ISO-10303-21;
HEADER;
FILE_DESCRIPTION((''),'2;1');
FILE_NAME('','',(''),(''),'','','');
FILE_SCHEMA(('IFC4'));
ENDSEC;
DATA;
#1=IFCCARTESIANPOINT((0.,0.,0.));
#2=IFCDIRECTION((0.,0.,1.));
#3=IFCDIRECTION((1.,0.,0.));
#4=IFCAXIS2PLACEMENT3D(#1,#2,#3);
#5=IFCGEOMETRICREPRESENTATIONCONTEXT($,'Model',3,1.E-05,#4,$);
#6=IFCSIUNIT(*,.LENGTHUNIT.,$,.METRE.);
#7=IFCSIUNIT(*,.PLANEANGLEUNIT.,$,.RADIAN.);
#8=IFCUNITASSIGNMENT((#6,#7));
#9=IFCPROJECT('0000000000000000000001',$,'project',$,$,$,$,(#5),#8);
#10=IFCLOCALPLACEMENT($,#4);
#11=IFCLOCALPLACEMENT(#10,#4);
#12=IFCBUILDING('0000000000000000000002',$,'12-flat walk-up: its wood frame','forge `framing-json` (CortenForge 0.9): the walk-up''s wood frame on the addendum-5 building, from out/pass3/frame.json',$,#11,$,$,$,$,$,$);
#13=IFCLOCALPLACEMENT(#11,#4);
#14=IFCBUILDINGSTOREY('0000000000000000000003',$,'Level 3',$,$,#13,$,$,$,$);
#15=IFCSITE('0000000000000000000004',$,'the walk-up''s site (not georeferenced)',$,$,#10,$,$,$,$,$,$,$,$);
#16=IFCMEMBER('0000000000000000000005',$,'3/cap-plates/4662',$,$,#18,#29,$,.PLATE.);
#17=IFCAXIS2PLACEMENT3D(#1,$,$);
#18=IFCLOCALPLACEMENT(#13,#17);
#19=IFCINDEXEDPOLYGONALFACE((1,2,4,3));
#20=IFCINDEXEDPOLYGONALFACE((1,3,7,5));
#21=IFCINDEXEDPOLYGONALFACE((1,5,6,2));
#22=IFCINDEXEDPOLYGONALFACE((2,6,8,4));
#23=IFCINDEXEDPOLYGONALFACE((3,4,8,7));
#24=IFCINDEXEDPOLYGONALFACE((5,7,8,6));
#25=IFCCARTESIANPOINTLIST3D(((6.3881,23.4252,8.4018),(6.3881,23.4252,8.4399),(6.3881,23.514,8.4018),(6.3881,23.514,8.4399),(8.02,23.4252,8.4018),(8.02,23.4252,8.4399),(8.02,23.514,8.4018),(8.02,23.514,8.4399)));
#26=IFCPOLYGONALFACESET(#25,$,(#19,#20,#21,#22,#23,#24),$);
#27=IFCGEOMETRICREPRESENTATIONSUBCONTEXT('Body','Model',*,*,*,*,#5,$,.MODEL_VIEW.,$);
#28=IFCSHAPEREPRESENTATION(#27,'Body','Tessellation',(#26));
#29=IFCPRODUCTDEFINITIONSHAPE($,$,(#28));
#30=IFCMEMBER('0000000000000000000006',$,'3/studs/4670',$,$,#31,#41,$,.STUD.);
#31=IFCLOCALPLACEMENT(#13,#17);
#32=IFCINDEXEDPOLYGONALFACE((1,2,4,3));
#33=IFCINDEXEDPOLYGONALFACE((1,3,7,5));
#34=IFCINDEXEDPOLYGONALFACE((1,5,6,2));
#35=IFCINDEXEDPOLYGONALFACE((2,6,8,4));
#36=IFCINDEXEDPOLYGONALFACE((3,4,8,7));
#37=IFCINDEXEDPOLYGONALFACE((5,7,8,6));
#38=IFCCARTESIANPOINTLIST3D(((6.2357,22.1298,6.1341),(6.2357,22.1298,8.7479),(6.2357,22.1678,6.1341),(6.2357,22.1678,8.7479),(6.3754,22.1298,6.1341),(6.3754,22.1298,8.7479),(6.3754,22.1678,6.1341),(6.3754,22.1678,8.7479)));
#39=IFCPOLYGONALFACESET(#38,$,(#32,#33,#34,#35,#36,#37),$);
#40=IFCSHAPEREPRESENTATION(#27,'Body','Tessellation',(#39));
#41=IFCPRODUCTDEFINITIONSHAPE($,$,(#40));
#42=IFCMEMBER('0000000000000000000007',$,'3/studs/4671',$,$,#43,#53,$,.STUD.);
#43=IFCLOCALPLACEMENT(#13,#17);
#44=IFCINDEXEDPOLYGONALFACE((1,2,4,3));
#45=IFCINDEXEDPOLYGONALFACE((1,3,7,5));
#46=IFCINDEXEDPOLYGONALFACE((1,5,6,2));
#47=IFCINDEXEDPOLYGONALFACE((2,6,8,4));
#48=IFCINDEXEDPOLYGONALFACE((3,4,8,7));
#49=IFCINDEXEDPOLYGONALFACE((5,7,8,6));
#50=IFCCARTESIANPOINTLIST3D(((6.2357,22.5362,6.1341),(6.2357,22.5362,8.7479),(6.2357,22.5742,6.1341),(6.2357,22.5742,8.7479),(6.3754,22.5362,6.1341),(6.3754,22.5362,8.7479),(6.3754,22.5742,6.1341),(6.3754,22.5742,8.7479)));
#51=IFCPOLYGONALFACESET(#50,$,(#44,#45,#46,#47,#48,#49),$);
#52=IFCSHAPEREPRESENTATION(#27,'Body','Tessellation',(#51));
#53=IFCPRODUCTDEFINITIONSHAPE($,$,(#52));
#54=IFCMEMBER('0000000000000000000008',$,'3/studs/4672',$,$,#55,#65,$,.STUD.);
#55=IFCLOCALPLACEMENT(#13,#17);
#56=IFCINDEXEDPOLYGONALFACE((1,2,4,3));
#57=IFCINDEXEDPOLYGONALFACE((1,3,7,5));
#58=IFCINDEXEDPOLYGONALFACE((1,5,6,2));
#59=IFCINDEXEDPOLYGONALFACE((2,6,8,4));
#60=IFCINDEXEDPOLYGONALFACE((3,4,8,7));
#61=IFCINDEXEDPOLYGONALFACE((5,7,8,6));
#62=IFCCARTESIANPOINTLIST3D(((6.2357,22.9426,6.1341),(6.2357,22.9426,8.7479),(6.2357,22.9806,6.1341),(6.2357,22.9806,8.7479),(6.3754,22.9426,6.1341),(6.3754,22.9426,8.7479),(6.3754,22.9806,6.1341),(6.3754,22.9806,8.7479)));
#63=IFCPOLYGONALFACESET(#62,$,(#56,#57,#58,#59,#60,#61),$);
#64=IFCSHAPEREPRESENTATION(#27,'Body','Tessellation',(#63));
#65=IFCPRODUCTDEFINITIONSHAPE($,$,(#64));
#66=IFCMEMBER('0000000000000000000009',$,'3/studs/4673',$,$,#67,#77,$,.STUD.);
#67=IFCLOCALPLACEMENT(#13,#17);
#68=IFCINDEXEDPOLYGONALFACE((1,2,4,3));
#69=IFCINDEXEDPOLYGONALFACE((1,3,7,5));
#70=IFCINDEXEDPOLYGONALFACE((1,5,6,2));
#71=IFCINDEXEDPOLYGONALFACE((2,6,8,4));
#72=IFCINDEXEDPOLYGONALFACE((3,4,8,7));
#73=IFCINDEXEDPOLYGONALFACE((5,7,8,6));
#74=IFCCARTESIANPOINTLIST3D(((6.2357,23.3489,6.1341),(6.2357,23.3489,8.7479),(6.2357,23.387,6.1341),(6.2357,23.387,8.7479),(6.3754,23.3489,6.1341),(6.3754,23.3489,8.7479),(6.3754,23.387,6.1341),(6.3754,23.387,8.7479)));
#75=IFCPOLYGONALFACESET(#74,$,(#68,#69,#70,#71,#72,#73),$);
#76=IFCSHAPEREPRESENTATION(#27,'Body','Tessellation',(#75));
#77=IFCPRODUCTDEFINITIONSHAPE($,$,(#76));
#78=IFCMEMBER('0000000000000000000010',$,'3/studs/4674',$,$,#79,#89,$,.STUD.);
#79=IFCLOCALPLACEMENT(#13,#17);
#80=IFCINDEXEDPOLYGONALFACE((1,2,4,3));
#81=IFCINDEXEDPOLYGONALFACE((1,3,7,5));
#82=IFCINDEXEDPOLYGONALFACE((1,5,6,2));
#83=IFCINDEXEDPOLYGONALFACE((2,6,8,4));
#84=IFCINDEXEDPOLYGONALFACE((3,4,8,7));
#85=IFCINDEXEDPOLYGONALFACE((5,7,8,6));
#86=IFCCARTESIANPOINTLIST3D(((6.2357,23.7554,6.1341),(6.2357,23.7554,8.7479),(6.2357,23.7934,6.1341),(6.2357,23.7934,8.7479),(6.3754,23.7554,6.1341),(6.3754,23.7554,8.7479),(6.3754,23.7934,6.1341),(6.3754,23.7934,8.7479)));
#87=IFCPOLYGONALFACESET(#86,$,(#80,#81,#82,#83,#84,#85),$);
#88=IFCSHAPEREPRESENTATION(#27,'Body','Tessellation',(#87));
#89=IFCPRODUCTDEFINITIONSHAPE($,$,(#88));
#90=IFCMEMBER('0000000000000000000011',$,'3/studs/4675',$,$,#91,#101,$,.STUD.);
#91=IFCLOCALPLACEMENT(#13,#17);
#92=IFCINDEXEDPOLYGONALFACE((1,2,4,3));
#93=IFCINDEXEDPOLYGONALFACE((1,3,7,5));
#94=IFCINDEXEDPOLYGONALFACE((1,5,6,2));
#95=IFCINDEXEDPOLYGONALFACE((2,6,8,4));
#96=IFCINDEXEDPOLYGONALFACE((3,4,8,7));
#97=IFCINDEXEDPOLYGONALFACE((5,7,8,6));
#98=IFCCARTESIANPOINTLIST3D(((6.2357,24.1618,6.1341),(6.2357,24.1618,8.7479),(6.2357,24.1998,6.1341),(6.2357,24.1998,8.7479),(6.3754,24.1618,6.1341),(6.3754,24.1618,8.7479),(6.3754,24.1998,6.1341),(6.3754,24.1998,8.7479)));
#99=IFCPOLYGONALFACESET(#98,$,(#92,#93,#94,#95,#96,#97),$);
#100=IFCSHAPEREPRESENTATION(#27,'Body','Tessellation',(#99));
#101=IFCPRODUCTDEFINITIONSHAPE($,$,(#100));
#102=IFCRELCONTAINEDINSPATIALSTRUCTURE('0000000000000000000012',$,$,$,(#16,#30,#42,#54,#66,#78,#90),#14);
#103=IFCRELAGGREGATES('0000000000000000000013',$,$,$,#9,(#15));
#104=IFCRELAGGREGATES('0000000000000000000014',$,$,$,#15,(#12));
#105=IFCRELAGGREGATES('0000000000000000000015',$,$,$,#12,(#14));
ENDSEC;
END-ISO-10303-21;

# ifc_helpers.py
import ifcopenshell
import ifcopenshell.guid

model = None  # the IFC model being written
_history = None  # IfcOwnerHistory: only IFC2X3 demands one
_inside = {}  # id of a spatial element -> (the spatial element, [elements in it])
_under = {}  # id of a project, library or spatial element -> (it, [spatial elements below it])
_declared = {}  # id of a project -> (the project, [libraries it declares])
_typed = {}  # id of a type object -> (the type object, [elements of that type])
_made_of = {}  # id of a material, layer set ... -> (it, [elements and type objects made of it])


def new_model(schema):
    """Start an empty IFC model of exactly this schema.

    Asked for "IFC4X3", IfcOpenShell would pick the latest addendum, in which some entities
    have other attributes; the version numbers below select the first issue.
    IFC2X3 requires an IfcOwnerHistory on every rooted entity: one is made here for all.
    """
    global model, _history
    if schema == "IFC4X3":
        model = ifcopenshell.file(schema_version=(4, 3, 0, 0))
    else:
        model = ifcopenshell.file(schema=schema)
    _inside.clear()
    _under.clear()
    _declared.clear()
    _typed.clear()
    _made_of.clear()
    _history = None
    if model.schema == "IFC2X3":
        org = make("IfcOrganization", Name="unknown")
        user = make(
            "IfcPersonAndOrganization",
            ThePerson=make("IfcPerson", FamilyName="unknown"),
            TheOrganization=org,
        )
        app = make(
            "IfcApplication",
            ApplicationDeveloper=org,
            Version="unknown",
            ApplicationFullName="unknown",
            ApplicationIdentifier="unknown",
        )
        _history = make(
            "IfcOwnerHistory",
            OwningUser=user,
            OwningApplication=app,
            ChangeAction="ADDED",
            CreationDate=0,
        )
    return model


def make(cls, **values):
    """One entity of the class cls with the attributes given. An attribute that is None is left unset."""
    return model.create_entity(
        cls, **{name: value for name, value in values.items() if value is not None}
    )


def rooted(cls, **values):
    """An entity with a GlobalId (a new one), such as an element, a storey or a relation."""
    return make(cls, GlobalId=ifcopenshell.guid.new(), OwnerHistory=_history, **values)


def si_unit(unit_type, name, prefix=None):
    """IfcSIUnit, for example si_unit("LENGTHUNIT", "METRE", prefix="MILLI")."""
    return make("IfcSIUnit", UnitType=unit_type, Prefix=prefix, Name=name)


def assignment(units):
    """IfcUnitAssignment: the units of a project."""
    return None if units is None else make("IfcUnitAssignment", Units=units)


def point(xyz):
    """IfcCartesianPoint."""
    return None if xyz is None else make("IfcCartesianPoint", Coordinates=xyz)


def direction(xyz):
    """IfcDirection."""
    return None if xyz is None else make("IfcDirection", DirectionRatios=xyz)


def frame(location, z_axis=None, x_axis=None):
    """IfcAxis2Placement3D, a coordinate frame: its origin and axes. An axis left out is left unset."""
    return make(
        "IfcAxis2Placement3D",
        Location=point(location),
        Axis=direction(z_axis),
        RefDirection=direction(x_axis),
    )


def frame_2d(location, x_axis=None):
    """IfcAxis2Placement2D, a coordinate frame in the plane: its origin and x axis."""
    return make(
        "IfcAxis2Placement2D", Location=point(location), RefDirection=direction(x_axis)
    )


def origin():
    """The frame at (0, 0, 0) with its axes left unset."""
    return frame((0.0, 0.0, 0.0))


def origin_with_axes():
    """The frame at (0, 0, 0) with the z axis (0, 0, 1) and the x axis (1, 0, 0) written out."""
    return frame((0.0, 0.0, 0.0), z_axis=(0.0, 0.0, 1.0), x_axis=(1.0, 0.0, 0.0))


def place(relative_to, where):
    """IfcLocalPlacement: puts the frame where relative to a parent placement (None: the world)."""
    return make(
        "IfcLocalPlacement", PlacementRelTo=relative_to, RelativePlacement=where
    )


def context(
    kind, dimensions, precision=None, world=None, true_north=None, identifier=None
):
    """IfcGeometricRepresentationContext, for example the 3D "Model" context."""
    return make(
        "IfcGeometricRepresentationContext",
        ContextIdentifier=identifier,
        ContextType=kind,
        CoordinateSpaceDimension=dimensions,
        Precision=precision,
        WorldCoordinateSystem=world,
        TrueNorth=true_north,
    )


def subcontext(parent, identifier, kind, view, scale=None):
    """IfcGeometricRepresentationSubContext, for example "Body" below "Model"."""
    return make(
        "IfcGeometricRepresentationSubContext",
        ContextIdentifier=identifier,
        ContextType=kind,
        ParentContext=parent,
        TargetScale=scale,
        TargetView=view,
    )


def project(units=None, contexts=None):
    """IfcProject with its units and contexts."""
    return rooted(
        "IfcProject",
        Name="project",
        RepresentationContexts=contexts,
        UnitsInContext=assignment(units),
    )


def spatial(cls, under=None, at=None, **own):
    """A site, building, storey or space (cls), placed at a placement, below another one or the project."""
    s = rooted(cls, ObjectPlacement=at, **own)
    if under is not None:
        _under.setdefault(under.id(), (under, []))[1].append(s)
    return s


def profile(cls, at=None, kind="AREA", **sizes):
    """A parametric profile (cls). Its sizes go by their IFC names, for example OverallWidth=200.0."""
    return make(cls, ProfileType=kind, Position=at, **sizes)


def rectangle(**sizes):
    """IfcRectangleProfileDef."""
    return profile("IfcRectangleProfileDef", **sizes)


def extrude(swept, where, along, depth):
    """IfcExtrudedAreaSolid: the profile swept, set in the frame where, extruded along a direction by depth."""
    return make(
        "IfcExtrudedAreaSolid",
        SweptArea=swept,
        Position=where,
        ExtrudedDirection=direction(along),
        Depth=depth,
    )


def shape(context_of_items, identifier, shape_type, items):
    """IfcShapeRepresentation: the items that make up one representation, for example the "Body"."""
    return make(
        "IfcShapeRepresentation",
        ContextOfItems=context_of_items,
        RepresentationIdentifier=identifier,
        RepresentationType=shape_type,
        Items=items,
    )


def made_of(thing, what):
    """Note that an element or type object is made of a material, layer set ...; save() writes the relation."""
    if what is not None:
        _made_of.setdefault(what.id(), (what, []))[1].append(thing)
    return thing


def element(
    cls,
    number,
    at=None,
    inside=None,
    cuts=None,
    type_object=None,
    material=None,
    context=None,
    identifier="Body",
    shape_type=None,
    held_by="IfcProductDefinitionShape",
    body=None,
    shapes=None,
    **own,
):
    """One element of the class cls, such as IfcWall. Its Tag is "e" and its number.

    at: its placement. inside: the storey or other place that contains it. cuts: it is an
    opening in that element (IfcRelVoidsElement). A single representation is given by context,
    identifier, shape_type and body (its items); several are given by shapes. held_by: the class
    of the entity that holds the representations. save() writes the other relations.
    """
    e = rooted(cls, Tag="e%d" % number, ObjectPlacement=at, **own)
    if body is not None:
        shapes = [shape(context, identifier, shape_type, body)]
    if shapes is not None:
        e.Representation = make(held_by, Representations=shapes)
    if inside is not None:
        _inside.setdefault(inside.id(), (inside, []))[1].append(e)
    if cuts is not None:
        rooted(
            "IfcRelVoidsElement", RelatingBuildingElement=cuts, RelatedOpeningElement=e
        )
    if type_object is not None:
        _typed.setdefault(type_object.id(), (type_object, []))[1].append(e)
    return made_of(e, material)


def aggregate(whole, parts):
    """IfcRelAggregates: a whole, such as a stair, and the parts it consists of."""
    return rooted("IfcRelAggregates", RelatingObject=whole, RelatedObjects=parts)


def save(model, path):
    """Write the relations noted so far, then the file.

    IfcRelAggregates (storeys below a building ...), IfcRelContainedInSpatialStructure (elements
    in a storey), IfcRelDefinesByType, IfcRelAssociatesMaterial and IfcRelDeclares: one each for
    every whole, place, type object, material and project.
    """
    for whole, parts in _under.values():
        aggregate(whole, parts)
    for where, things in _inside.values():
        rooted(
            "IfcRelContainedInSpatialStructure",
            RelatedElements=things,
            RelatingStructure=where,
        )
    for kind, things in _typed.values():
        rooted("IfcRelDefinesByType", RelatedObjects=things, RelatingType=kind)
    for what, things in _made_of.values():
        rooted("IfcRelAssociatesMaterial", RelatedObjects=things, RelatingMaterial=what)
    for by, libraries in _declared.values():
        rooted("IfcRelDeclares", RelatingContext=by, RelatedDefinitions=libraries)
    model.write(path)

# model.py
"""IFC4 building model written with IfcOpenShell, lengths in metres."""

from ifc_helpers import new_model, si_unit, frame, frame_2d, origin, origin_with_axes, place, context, subcontext, project, spatial, rectangle, extrude, element, save


model = new_model("IFC4")

# Units and contexts
model_context = context("Model", 3, precision=1e-05, world=origin_with_axes())
body_context = subcontext(model_context, "Body", "Model", "MODEL_VIEW")
ifc_project = project(units=[si_unit("LENGTHUNIT", "METRE"), si_unit("PLANEANGLEUNIT", "RADIAN")], contexts=[model_context])

# Site, building, storey
site_placement = place(None, origin_with_axes())
site = spatial("IfcSite", under=ifc_project, at=site_placement, Name="the walk-up's site (not georeferenced)")
building_placement = place(site_placement, origin_with_axes())
building = spatial("IfcBuilding", under=site, at=building_placement, Name="12-flat walk-up: its wood frame", Description="forge `framing-json` (CortenForge 0.9): the walk-up's wood frame on the addendum-5 building, from out/pass3/frame.json")
storey_placement = place(building_placement, origin_with_axes())
storey = spatial("IfcBuildingStorey", under=building, at=storey_placement, Name="Level 3")

# Members
member_1_placement = place(storey_placement, frame((6.3881, 23.4251, 8.4018), z_axis=(0.0, 0.0, 1.0), x_axis=(1.0, 0.0, 0.0)))
element("IfcMember", 1, at=member_1_placement, inside=storey, Name="3/cap-plates/4662", PredefinedType="PLATE", context=body_context, shape_type="SweptSolid", body=[
    extrude(rectangle(XDim=1.6319, YDim=0.0889, at=frame_2d((0.816, 0.0445))), origin(), (0.0, 0.0, 1.0), 0.0381),
])
for number, where, z_axis, x_axis, name in (
    (2, (6.2357, 22.1298, 6.1341), (0.0, 0.0, 1.0), (1.0, 0.0, 0.0), "3/studs/4670"),
    (3, (6.2357, 22.5361, 6.1341), (0.0, 0.0, 1.0), (1.0, 0.0, 0.0), "3/studs/4671"),
    (4, (6.2357, 22.9426, 6.1341), (0.0, 0.0, 1.0), (1.0, 0.0, 0.0), "3/studs/4672"),
    (5, (6.2357, 23.3489, 6.1341), (0.0, 0.0, 1.0), (1.0, 0.0, 0.0), "3/studs/4673"),
    (6, (6.2357, 23.7553, 6.1341), (0.0, 0.0, 1.0), (1.0, 0.0, 0.0), "3/studs/4674"),
    (7, (6.2357, 24.1618, 6.1341), (0.0, 0.0, 1.0), (1.0, 0.0, 0.0), "3/studs/4675"),
):
    element("IfcMember", number, at=place(storey_placement, frame(where, z_axis=z_axis, x_axis=x_axis)), inside=storey, Name=name, PredefinedType="STUD", context=body_context, shape_type="SweptSolid", body=[
        extrude(rectangle(XDim=0.1397, YDim=0.0381, at=frame_2d((0.0699, 0.0191))), origin(), (0.0, 0.0, 1.0), 2.6138),
    ])

save(model, "model.ifc")
